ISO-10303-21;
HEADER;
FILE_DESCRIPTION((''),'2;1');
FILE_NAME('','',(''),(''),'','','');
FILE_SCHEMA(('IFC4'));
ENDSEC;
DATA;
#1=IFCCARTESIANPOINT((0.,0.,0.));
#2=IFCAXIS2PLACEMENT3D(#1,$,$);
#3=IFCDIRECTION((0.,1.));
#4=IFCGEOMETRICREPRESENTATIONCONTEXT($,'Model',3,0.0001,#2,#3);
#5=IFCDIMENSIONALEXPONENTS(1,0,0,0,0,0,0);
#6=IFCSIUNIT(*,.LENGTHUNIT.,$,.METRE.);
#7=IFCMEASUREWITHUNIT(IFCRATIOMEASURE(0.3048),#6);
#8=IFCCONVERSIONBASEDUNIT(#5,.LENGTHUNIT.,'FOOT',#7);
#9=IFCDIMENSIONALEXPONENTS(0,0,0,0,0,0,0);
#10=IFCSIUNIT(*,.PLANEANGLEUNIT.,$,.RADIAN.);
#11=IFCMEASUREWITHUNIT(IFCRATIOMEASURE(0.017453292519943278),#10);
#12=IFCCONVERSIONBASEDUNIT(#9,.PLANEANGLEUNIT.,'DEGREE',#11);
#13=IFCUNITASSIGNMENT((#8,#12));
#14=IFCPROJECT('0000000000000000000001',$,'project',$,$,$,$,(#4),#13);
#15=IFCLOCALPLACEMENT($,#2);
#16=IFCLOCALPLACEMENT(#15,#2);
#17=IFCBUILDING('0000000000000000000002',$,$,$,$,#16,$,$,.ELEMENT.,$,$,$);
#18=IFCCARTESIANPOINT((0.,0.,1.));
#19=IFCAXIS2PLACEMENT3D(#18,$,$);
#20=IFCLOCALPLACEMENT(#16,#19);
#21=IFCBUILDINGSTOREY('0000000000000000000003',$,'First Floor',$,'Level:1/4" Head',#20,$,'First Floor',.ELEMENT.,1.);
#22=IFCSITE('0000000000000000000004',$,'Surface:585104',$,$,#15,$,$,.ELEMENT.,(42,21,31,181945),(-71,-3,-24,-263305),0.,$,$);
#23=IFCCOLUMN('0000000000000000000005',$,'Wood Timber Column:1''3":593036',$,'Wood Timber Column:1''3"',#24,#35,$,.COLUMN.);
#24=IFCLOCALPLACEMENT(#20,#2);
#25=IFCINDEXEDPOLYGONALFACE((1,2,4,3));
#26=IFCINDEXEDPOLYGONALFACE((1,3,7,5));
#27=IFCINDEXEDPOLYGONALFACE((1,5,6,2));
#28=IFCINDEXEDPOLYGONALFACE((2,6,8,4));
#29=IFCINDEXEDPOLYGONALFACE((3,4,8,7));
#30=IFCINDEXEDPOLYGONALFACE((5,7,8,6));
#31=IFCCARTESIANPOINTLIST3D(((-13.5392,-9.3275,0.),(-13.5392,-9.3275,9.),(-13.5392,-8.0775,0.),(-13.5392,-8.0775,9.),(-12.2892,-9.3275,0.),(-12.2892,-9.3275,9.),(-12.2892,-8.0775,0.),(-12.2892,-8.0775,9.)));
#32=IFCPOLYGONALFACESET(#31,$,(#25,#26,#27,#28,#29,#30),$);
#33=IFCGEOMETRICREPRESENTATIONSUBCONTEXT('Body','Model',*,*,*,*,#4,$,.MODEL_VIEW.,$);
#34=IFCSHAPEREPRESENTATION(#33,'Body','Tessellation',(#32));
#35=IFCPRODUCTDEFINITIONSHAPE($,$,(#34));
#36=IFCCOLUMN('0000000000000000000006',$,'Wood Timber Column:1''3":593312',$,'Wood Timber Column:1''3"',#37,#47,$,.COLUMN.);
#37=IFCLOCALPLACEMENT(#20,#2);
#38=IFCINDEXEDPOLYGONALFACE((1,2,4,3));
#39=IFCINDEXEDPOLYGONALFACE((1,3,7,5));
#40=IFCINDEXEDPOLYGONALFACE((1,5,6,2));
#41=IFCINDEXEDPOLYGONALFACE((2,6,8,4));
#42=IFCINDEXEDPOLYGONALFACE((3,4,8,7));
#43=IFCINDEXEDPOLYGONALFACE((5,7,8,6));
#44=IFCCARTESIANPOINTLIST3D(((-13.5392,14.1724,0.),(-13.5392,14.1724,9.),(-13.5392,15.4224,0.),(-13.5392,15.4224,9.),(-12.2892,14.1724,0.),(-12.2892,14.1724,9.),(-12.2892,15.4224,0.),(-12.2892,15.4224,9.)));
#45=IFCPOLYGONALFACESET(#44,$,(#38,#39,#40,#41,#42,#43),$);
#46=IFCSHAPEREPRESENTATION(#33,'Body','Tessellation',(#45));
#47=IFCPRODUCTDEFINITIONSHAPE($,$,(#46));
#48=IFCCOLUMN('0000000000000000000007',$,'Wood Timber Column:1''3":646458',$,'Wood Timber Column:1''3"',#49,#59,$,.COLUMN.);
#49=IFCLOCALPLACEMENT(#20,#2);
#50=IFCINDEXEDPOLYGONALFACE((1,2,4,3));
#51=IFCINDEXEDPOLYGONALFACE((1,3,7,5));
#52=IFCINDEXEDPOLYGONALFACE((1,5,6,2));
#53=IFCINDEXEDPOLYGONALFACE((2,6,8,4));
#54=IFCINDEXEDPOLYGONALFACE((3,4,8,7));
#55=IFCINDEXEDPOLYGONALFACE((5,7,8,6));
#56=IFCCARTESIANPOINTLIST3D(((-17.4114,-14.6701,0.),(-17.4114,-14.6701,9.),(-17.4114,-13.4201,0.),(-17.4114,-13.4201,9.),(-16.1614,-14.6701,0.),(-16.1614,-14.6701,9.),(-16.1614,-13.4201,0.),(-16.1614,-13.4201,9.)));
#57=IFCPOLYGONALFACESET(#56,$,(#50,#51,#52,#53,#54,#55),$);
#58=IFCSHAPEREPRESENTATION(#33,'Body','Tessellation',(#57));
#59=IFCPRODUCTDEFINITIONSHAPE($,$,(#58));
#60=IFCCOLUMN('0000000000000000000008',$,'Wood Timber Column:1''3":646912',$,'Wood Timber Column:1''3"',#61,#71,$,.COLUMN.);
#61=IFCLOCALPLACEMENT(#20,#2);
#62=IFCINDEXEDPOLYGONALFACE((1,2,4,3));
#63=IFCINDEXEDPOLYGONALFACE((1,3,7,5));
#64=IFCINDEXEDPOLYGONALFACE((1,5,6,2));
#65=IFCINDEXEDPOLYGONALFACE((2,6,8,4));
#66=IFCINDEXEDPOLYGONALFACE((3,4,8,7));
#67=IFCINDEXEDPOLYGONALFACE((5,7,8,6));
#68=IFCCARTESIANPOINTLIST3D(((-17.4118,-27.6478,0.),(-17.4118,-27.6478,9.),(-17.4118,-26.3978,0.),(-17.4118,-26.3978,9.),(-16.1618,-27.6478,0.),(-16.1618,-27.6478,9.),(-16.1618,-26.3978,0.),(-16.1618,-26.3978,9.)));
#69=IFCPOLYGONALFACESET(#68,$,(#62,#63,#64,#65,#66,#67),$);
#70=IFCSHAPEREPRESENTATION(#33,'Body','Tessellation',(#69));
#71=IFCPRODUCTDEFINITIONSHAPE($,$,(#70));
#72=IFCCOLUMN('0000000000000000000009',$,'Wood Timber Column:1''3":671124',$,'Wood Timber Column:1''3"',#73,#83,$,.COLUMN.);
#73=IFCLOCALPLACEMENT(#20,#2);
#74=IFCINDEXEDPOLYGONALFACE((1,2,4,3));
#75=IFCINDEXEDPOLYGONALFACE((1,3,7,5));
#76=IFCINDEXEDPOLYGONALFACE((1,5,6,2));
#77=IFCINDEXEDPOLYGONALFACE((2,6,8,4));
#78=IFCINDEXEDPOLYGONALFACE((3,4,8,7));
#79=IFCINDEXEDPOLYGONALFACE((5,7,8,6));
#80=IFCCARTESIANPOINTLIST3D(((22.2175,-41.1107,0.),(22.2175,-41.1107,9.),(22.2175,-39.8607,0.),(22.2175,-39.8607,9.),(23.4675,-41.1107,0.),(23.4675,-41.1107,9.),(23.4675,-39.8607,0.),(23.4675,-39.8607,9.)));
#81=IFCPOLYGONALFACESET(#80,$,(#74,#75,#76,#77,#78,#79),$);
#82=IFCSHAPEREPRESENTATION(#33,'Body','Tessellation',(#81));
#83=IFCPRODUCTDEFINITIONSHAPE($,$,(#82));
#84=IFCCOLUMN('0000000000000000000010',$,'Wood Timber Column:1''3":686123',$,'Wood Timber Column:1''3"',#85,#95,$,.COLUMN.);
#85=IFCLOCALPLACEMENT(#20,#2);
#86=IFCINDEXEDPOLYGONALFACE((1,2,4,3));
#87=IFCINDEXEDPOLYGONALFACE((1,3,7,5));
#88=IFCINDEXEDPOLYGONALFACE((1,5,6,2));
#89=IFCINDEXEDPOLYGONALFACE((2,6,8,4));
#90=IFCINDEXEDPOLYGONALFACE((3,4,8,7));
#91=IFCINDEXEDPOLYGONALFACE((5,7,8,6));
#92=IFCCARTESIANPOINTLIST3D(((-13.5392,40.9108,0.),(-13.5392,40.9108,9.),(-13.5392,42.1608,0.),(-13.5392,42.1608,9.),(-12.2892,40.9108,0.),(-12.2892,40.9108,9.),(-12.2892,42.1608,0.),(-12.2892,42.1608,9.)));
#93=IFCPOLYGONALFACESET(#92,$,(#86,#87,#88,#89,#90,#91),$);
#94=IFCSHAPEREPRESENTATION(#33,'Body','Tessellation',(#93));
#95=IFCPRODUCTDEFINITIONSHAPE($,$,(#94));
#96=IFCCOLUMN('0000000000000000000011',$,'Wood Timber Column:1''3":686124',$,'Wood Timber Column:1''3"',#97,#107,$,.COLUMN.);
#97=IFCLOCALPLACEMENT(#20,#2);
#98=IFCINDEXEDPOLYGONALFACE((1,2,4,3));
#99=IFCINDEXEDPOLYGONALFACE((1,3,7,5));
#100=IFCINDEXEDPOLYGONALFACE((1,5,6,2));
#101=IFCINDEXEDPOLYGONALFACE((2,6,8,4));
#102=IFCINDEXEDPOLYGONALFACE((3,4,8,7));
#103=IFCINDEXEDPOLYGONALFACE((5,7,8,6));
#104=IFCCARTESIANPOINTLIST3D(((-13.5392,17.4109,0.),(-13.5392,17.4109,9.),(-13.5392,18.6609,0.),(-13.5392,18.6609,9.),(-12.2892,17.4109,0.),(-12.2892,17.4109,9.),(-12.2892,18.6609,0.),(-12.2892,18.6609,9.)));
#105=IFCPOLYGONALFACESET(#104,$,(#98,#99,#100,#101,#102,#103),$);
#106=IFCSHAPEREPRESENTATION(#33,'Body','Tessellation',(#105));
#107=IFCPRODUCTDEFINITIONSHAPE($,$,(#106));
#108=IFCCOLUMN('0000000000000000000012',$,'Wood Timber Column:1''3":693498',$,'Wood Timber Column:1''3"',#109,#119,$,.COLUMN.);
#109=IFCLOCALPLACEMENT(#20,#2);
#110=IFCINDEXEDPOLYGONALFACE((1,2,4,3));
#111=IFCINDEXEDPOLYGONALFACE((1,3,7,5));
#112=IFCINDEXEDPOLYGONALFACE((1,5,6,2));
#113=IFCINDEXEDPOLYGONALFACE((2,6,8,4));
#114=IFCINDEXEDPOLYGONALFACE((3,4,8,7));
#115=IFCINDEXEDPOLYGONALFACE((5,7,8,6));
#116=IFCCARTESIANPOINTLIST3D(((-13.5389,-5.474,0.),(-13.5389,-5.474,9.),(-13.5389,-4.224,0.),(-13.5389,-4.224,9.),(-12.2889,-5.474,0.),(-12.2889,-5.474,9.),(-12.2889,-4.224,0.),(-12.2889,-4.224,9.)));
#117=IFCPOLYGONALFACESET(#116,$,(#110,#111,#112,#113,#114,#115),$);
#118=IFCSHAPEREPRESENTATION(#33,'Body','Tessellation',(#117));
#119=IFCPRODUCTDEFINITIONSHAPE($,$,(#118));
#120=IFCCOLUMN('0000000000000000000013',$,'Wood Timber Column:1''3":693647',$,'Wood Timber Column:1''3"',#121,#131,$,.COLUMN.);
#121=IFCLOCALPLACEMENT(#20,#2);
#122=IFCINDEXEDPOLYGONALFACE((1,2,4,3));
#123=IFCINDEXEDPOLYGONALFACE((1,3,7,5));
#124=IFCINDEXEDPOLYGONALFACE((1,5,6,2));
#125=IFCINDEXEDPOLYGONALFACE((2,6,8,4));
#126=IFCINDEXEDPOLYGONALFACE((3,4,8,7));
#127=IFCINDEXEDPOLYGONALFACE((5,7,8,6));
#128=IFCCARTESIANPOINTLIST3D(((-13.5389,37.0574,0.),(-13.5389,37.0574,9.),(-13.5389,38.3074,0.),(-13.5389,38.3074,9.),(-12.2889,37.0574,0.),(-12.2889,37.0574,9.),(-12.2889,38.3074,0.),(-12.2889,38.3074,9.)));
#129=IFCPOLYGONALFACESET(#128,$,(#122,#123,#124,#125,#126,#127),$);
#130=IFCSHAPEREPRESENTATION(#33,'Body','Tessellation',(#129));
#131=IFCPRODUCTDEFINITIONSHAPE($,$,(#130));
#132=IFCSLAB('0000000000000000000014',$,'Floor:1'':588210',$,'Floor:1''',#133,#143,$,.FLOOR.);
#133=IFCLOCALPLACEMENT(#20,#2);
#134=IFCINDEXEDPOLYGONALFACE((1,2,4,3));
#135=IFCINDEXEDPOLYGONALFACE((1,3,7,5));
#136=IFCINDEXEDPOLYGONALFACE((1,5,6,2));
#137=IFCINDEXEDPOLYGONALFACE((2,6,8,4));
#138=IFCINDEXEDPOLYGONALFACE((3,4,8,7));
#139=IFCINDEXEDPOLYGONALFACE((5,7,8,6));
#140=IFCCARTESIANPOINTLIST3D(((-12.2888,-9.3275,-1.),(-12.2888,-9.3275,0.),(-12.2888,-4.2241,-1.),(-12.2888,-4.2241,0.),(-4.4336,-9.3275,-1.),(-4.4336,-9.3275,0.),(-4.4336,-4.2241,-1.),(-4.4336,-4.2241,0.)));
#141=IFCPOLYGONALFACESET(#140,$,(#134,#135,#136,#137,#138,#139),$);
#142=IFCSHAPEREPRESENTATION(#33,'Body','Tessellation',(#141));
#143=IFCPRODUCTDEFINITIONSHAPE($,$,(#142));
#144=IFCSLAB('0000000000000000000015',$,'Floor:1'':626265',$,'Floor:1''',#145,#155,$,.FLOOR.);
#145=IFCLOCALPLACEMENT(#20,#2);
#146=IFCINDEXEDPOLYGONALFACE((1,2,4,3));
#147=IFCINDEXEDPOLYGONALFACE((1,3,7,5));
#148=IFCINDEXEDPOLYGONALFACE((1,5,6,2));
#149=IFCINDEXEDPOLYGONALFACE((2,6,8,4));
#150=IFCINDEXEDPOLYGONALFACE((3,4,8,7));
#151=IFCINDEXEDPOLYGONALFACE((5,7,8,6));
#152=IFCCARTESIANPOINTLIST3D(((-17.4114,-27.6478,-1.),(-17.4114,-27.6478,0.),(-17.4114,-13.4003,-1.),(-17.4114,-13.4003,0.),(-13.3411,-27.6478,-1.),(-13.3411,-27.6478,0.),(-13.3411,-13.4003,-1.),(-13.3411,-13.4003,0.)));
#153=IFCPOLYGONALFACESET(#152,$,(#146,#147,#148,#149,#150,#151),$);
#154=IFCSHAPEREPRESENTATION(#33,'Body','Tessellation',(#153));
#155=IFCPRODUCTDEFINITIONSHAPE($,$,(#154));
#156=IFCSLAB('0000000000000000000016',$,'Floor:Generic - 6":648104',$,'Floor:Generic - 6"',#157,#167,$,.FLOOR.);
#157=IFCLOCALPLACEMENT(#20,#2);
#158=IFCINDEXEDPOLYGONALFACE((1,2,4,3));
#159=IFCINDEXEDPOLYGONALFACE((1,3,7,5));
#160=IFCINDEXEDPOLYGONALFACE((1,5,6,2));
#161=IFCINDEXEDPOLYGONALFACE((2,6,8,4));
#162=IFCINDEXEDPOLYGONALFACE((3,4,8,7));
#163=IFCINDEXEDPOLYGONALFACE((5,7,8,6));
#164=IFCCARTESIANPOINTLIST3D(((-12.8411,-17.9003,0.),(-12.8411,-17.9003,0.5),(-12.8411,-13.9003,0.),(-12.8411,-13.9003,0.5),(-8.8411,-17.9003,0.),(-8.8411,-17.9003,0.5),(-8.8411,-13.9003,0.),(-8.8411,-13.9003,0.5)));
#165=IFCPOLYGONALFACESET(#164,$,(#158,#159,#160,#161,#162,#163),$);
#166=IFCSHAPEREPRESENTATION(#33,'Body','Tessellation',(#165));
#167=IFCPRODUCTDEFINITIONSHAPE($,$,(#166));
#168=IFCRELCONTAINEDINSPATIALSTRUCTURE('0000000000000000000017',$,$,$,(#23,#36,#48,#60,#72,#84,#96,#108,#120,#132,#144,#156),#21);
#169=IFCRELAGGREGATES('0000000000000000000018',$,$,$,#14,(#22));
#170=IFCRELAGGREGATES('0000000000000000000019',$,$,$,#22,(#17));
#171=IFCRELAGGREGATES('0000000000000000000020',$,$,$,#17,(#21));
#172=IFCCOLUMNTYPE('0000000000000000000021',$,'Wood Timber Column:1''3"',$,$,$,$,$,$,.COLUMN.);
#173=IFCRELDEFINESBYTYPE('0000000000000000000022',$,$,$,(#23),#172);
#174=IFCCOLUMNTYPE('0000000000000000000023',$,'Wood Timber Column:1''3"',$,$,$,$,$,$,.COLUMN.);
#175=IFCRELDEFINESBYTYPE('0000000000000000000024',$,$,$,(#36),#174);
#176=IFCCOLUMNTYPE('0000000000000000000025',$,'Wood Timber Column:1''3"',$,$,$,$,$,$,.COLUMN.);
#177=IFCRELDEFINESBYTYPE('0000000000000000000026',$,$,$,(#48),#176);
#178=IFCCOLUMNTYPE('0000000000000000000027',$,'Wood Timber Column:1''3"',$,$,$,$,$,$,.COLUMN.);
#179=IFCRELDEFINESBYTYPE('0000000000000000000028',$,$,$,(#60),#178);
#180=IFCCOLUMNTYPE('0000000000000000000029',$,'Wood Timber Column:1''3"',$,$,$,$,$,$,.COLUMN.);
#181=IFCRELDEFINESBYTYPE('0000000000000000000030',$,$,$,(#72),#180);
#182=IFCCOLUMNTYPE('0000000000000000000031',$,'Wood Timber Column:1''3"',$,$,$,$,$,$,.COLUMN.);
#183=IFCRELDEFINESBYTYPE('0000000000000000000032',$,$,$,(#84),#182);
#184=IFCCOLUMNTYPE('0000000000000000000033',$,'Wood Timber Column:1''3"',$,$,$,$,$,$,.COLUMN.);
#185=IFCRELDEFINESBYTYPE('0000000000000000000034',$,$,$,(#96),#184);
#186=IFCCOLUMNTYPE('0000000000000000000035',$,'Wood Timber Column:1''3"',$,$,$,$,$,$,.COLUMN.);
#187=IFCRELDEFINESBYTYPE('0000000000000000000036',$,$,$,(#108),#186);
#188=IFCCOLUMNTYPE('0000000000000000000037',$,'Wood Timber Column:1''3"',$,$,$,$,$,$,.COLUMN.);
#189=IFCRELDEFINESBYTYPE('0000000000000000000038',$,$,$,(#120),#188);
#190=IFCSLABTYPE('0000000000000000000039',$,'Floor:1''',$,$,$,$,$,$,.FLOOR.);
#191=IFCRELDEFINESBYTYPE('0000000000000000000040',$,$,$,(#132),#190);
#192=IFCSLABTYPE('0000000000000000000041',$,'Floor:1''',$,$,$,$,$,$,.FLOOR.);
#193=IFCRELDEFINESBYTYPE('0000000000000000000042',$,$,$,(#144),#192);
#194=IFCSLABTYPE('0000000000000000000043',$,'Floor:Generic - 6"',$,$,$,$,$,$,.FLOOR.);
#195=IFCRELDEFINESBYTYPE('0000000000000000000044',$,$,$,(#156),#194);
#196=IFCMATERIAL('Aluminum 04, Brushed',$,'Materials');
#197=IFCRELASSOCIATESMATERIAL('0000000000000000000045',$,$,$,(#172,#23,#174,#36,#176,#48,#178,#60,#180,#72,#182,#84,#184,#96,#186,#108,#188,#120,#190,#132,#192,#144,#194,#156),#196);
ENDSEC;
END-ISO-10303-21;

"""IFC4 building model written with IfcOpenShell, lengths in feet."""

from ifc_helpers import new_model, entity, si_unit, converted_unit, direction, frame, origin, place, context, subcontext, project, spatial, indexed_curve, outline, extrude, source, transform, mapped, material, type_object, type_shapes, element, save


model = new_model("IFC4")

# Units and contexts
model_context = context("Model", 3, precision=0.0001, world=origin(), true_north=direction((0.0, 1.0)))
body_context = subcontext(model_context, "Body", "Model", "MODEL_VIEW")
ifc_project = project(units=[converted_unit("LENGTHUNIT", "FOOT", entity("IfcRatioMeasure", 0.3048), si_unit("LENGTHUNIT", "METRE"), dimensions=[1, 0, 0, 0, 0, 0, 0]), converted_unit("PLANEANGLEUNIT", "DEGREE", entity("IfcRatioMeasure", 0.017453292519943278), si_unit("PLANEANGLEUNIT", "RADIAN"), dimensions=[0, 0, 0, 0, 0, 0, 0])], contexts=[model_context])

# Site, building, storey
site_placement = place(None, origin())
site = spatial("IfcSite", under=ifc_project, at=site_placement, Name="Surface:585104", CompositionType="ELEMENT", RefLatitude=(42, 21, 31, 181945), RefLongitude=(-71, -3, -24, -263305), RefElevation=0.0)
building_placement = place(site_placement, origin())
building = spatial("IfcBuilding", under=site, at=building_placement, CompositionType="ELEMENT")
storey_placement = place(building_placement, frame((0.0, 0.0, 1.0)))
storey = spatial("IfcBuildingStorey", under=building, at=storey_placement, Name="First Floor", ObjectType="Level:1/4\" Head", LongName="First Floor", CompositionType="ELEMENT", Elevation=1.0)

# Columns
ifc_material_1 = material(Name="Aluminum 04, Brushed", Category="Materials")
column_type_1 = type_object("IfcColumnType", Name="Wood Timber Column:1'3\"", PredefinedType="COLUMN", material=ifc_material_1)
shared_shape_1 = source(origin(), body_context, "Body", "SweptSolid", [
    extrude(outline(indexed_curve([(-0.625, -0.625), (0.625, -0.625), (0.625, 0.625), (-0.625, 0.625), (-0.625, -0.625)], self_intersect=False)), frame((-12.9142, -8.7025, 1.0), z_axis=(0.0, 0.0, 1.0), x_axis=(0.0, -1.0, 0.0)), (0.0, 0.0, 1.0), 9.0),
])
type_shapes(column_type_1, [shared_shape_1])
column_1_placement = place(storey_placement, frame((0.0, 0.0, -1.0)))
element("IfcColumn", 1, at=column_1_placement, inside=storey, type_object=column_type_1, material=ifc_material_1, Name="Wood Timber Column:1'3\":593036", ObjectType="Wood Timber Column:1'3\"", PredefinedType="COLUMN", context=body_context, shape_type="MappedRepresentation", body=[
    mapped(shared_shape_1, transform((0.0, 0.0, 0.0), scale=1.0)),
])
column_type_2 = type_object("IfcColumnType", Name="Wood Timber Column:1'3\"", PredefinedType="COLUMN", material=ifc_material_1)
shared_shape_2 = source(origin(), body_context, "Body", "SweptSolid", [
    extrude(outline(indexed_curve([(-0.625, -0.625), (0.625, -0.625), (0.625, 0.625), (-0.625, 0.625), (-0.625, -0.625)], self_intersect=False)), frame((-12.9142, 14.7974, 1.0), z_axis=(0.0, 0.0, 1.0), x_axis=(0.0, -1.0, 0.0)), (0.0, 0.0, 1.0), 9.0),
])
type_shapes(column_type_2, [shared_shape_2])
column_2_placement = place(storey_placement, frame((0.0, 0.0, -1.0)))
element("IfcColumn", 2, at=column_2_placement, inside=storey, type_object=column_type_2, material=ifc_material_1, Name="Wood Timber Column:1'3\":593312", ObjectType="Wood Timber Column:1'3\"", PredefinedType="COLUMN", context=body_context, shape_type="MappedRepresentation", body=[
    mapped(shared_shape_2, transform((0.0, 0.0, 0.0), scale=1.0)),
])
column_type_3 = type_object("IfcColumnType", Name="Wood Timber Column:1'3\"", PredefinedType="COLUMN", material=ifc_material_1)
shared_shape_3 = source(origin(), body_context, "Body", "SweptSolid", [
    extrude(outline(indexed_curve([(-0.625, -0.625), (0.625, -0.625), (0.625, 0.625), (-0.625, 0.625), (-0.625, -0.625)], self_intersect=False)), frame((-16.7864, -14.0451, 1.0), z_axis=(0.0, 0.0, 1.0), x_axis=(0.0, -1.0, 0.0)), (0.0, 0.0, 1.0), 9.0),
])
type_shapes(column_type_3, [shared_shape_3])
column_3_placement = place(storey_placement, frame((0.0, 0.0, -1.0)))
element("IfcColumn", 3, at=column_3_placement, inside=storey, type_object=column_type_3, material=ifc_material_1, Name="Wood Timber Column:1'3\":646458", ObjectType="Wood Timber Column:1'3\"", PredefinedType="COLUMN", context=body_context, shape_type="MappedRepresentation", body=[
    mapped(shared_shape_3, transform((0.0, 0.0, 0.0), scale=1.0)),
])
column_type_4 = type_object("IfcColumnType", Name="Wood Timber Column:1'3\"", PredefinedType="COLUMN", material=ifc_material_1)
shared_shape_4 = source(origin(), body_context, "Body", "SweptSolid", [
    extrude(outline(indexed_curve([(-0.625, -0.625), (0.625, -0.625), (0.625, 0.625), (-0.625, 0.625), (-0.625, -0.625)], self_intersect=False)), frame((-16.7868, -27.0228, 1.0), z_axis=(0.0, 0.0, 1.0), x_axis=(0.0, -1.0, 0.0)), (0.0, 0.0, 1.0), 9.0),
])
type_shapes(column_type_4, [shared_shape_4])
column_4_placement = place(storey_placement, frame((0.0, 0.0, -1.0)))
element("IfcColumn", 4, at=column_4_placement, inside=storey, type_object=column_type_4, material=ifc_material_1, Name="Wood Timber Column:1'3\":646912", ObjectType="Wood Timber Column:1'3\"", PredefinedType="COLUMN", context=body_context, shape_type="MappedRepresentation", body=[
    mapped(shared_shape_4, transform((0.0, 0.0, 0.0), scale=1.0)),
])
column_type_5 = type_object("IfcColumnType", Name="Wood Timber Column:1'3\"", PredefinedType="COLUMN", material=ifc_material_1)
shared_shape_5 = source(origin(), body_context, "Body", "SweptSolid", [
    extrude(outline(indexed_curve([(-0.625, -0.625), (0.625, -0.625), (0.625, 0.625), (-0.625, 0.625), (-0.625, -0.625)], self_intersect=False)), frame((22.8425, -40.4857, 1.0), z_axis=(0.0, 0.0, 1.0), x_axis=(0.0, -1.0, 0.0)), (0.0, 0.0, 1.0), 9.0),
])
type_shapes(column_type_5, [shared_shape_5])
column_5_placement = place(storey_placement, frame((0.0, 0.0, -1.0)))
element("IfcColumn", 5, at=column_5_placement, inside=storey, type_object=column_type_5, material=ifc_material_1, Name="Wood Timber Column:1'3\":671124", ObjectType="Wood Timber Column:1'3\"", PredefinedType="COLUMN", context=body_context, shape_type="MappedRepresentation", body=[
    mapped(shared_shape_5, transform((0.0, 0.0, 0.0), scale=1.0)),
])
column_type_6 = type_object("IfcColumnType", Name="Wood Timber Column:1'3\"", PredefinedType="COLUMN", material=ifc_material_1)
shared_shape_6 = source(origin(), body_context, "Body", "SweptSolid", [
    extrude(outline(indexed_curve([(-0.625, -0.625), (0.625, -0.625), (0.625, 0.625), (-0.625, 0.625), (-0.625, -0.625)], self_intersect=False)), frame((-12.9142, 41.5358, 1.0), z_axis=(0.0, 0.0, 1.0), x_axis=(0.0, -1.0, 0.0)), (0.0, 0.0, 1.0), 9.0),
])
type_shapes(column_type_6, [shared_shape_6])
column_6_placement = place(storey_placement, frame((0.0, 0.0, -1.0)))
element("IfcColumn", 6, at=column_6_placement, inside=storey, type_object=column_type_6, material=ifc_material_1, Name="Wood Timber Column:1'3\":686123", ObjectType="Wood Timber Column:1'3\"", PredefinedType="COLUMN", context=body_context, shape_type="MappedRepresentation", body=[
    mapped(shared_shape_6, transform((0.0, 0.0, 0.0), scale=1.0)),
])
column_type_7 = type_object("IfcColumnType", Name="Wood Timber Column:1'3\"", PredefinedType="COLUMN", material=ifc_material_1)
shared_shape_7 = source(origin(), body_context, "Body", "SweptSolid", [
    extrude(outline(indexed_curve([(-0.625, -0.625), (0.625, -0.625), (0.625, 0.625), (-0.625, 0.625), (-0.625, -0.625)], self_intersect=False)), frame((-12.9142, 18.0359, 1.0), z_axis=(0.0, 0.0, 1.0), x_axis=(0.0, -1.0, 0.0)), (0.0, 0.0, 1.0), 9.0),
])
type_shapes(column_type_7, [shared_shape_7])
column_7_placement = place(storey_placement, frame((0.0, 0.0, -1.0)))
element("IfcColumn", 7, at=column_7_placement, inside=storey, type_object=column_type_7, material=ifc_material_1, Name="Wood Timber Column:1'3\":686124", ObjectType="Wood Timber Column:1'3\"", PredefinedType="COLUMN", context=body_context, shape_type="MappedRepresentation", body=[
    mapped(shared_shape_7, transform((0.0, 0.0, 0.0), scale=1.0)),
])
column_type_8 = type_object("IfcColumnType", Name="Wood Timber Column:1'3\"", PredefinedType="COLUMN", material=ifc_material_1)
shared_shape_8 = source(origin(), body_context, "Body", "SweptSolid", [
    extrude(outline(indexed_curve([(-0.625, -0.625), (0.625, -0.625), (0.625, 0.625), (-0.625, 0.625), (-0.625, -0.625)], self_intersect=False)), frame((-12.9139, -4.849, 1.0), z_axis=(0.0, 0.0, 1.0), x_axis=(0.0, -1.0, 0.0)), (0.0, 0.0, 1.0), 9.0),
])
type_shapes(column_type_8, [shared_shape_8])
column_8_placement = place(storey_placement, frame((0.0, 0.0, -1.0)))
element("IfcColumn", 8, at=column_8_placement, inside=storey, type_object=column_type_8, material=ifc_material_1, Name="Wood Timber Column:1'3\":693498", ObjectType="Wood Timber Column:1'3\"", PredefinedType="COLUMN", context=body_context, shape_type="MappedRepresentation", body=[
    mapped(shared_shape_8, transform((0.0, 0.0, 0.0), scale=1.0)),
])
column_type_9 = type_object("IfcColumnType", Name="Wood Timber Column:1'3\"", PredefinedType="COLUMN", material=ifc_material_1)
shared_shape_9 = source(origin(), body_context, "Body", "SweptSolid", [
    extrude(outline(indexed_curve([(-0.625, -0.625), (0.625, -0.625), (0.625, 0.625), (-0.625, 0.625), (-0.625, -0.625)], self_intersect=False)), frame((-12.9139, 37.6824, 1.0), z_axis=(0.0, 0.0, 1.0), x_axis=(0.0, -1.0, 0.0)), (0.0, 0.0, 1.0), 9.0),
])
type_shapes(column_type_9, [shared_shape_9])
column_9_placement = place(storey_placement, frame((0.0, 0.0, -1.0)))
element("IfcColumn", 9, at=column_9_placement, inside=storey, type_object=column_type_9, material=ifc_material_1, Name="Wood Timber Column:1'3\":693647", ObjectType="Wood Timber Column:1'3\"", PredefinedType="COLUMN", context=body_context, shape_type="MappedRepresentation", body=[
    mapped(shared_shape_9, transform((0.0, 0.0, 0.0), scale=1.0)),
])

# Slabs
slab_type_1 = type_object("IfcSlabType", Name="Floor:1'", PredefinedType="FLOOR", material=ifc_material_1)
slab_1_placement = place(storey_placement, origin())
element("IfcSlab", 10, at=slab_1_placement, inside=storey, type_object=slab_type_1, material=ifc_material_1, Name="Floor:1':588210", ObjectType="Floor:1'", PredefinedType="FLOOR", context=body_context, shape_type="SweptSolid", body=[
    extrude(outline(indexed_curve([(-2.5517, -3.9276), (2.5517, -3.9276), (2.5517, 3.9276), (-2.5517, 3.9276), (-2.5517, -3.9276)], self_intersect=False)), frame((-8.3612, -6.7758, 0.0), z_axis=(0.0, 0.0, -1.0), x_axis=(0.0, 1.0, 0.0)), (0.0, 0.0, 1.0), 1.0),
])
slab_type_2 = type_object("IfcSlabType", Name="Floor:1'", PredefinedType="FLOOR", material=ifc_material_1)
slab_2_placement = place(storey_placement, origin())
element("IfcSlab", 11, at=slab_2_placement, inside=storey, type_object=slab_type_2, material=ifc_material_1, Name="Floor:1':626265", ObjectType="Floor:1'", PredefinedType="FLOOR", context=body_context, shape_type="SweptSolid", body=[
    extrude(outline(indexed_curve([(-7.1237, -2.0351), (7.1237, -2.0351), (7.1237, 2.0351), (-7.1237, 2.0351), (-7.1237, -2.0351)], self_intersect=False)), frame((-15.3762, -20.5241, 0.0), z_axis=(0.0, 0.0, -1.0), x_axis=(0.0, 1.0, 0.0)), (0.0, 0.0, 1.0), 1.0),
])
slab_type_3 = type_object("IfcSlabType", Name="Floor:Generic - 6\"", PredefinedType="FLOOR", material=ifc_material_1)
slab_3_placement = place(storey_placement, origin())
element("IfcSlab", 12, at=slab_3_placement, inside=storey, type_object=slab_type_3, material=ifc_material_1, Name="Floor:Generic - 6\":648104", ObjectType="Floor:Generic - 6\"", PredefinedType="FLOOR", context=body_context, shape_type="SweptSolid", body=[
    extrude(outline(indexed_curve([(-2.0, -2.0), (2.0, -2.0), (2.0, 2.0), (-2.0, 2.0), (-2.0, -2.0)], self_intersect=False)), frame((-10.8411, -15.9003, 0.5), z_axis=(0.0, 0.0, -1.0), x_axis=(0.0, 1.0, 0.0)), (0.0, 0.0, 1.0), 0.5),
])

save(model, "model.ifc")
